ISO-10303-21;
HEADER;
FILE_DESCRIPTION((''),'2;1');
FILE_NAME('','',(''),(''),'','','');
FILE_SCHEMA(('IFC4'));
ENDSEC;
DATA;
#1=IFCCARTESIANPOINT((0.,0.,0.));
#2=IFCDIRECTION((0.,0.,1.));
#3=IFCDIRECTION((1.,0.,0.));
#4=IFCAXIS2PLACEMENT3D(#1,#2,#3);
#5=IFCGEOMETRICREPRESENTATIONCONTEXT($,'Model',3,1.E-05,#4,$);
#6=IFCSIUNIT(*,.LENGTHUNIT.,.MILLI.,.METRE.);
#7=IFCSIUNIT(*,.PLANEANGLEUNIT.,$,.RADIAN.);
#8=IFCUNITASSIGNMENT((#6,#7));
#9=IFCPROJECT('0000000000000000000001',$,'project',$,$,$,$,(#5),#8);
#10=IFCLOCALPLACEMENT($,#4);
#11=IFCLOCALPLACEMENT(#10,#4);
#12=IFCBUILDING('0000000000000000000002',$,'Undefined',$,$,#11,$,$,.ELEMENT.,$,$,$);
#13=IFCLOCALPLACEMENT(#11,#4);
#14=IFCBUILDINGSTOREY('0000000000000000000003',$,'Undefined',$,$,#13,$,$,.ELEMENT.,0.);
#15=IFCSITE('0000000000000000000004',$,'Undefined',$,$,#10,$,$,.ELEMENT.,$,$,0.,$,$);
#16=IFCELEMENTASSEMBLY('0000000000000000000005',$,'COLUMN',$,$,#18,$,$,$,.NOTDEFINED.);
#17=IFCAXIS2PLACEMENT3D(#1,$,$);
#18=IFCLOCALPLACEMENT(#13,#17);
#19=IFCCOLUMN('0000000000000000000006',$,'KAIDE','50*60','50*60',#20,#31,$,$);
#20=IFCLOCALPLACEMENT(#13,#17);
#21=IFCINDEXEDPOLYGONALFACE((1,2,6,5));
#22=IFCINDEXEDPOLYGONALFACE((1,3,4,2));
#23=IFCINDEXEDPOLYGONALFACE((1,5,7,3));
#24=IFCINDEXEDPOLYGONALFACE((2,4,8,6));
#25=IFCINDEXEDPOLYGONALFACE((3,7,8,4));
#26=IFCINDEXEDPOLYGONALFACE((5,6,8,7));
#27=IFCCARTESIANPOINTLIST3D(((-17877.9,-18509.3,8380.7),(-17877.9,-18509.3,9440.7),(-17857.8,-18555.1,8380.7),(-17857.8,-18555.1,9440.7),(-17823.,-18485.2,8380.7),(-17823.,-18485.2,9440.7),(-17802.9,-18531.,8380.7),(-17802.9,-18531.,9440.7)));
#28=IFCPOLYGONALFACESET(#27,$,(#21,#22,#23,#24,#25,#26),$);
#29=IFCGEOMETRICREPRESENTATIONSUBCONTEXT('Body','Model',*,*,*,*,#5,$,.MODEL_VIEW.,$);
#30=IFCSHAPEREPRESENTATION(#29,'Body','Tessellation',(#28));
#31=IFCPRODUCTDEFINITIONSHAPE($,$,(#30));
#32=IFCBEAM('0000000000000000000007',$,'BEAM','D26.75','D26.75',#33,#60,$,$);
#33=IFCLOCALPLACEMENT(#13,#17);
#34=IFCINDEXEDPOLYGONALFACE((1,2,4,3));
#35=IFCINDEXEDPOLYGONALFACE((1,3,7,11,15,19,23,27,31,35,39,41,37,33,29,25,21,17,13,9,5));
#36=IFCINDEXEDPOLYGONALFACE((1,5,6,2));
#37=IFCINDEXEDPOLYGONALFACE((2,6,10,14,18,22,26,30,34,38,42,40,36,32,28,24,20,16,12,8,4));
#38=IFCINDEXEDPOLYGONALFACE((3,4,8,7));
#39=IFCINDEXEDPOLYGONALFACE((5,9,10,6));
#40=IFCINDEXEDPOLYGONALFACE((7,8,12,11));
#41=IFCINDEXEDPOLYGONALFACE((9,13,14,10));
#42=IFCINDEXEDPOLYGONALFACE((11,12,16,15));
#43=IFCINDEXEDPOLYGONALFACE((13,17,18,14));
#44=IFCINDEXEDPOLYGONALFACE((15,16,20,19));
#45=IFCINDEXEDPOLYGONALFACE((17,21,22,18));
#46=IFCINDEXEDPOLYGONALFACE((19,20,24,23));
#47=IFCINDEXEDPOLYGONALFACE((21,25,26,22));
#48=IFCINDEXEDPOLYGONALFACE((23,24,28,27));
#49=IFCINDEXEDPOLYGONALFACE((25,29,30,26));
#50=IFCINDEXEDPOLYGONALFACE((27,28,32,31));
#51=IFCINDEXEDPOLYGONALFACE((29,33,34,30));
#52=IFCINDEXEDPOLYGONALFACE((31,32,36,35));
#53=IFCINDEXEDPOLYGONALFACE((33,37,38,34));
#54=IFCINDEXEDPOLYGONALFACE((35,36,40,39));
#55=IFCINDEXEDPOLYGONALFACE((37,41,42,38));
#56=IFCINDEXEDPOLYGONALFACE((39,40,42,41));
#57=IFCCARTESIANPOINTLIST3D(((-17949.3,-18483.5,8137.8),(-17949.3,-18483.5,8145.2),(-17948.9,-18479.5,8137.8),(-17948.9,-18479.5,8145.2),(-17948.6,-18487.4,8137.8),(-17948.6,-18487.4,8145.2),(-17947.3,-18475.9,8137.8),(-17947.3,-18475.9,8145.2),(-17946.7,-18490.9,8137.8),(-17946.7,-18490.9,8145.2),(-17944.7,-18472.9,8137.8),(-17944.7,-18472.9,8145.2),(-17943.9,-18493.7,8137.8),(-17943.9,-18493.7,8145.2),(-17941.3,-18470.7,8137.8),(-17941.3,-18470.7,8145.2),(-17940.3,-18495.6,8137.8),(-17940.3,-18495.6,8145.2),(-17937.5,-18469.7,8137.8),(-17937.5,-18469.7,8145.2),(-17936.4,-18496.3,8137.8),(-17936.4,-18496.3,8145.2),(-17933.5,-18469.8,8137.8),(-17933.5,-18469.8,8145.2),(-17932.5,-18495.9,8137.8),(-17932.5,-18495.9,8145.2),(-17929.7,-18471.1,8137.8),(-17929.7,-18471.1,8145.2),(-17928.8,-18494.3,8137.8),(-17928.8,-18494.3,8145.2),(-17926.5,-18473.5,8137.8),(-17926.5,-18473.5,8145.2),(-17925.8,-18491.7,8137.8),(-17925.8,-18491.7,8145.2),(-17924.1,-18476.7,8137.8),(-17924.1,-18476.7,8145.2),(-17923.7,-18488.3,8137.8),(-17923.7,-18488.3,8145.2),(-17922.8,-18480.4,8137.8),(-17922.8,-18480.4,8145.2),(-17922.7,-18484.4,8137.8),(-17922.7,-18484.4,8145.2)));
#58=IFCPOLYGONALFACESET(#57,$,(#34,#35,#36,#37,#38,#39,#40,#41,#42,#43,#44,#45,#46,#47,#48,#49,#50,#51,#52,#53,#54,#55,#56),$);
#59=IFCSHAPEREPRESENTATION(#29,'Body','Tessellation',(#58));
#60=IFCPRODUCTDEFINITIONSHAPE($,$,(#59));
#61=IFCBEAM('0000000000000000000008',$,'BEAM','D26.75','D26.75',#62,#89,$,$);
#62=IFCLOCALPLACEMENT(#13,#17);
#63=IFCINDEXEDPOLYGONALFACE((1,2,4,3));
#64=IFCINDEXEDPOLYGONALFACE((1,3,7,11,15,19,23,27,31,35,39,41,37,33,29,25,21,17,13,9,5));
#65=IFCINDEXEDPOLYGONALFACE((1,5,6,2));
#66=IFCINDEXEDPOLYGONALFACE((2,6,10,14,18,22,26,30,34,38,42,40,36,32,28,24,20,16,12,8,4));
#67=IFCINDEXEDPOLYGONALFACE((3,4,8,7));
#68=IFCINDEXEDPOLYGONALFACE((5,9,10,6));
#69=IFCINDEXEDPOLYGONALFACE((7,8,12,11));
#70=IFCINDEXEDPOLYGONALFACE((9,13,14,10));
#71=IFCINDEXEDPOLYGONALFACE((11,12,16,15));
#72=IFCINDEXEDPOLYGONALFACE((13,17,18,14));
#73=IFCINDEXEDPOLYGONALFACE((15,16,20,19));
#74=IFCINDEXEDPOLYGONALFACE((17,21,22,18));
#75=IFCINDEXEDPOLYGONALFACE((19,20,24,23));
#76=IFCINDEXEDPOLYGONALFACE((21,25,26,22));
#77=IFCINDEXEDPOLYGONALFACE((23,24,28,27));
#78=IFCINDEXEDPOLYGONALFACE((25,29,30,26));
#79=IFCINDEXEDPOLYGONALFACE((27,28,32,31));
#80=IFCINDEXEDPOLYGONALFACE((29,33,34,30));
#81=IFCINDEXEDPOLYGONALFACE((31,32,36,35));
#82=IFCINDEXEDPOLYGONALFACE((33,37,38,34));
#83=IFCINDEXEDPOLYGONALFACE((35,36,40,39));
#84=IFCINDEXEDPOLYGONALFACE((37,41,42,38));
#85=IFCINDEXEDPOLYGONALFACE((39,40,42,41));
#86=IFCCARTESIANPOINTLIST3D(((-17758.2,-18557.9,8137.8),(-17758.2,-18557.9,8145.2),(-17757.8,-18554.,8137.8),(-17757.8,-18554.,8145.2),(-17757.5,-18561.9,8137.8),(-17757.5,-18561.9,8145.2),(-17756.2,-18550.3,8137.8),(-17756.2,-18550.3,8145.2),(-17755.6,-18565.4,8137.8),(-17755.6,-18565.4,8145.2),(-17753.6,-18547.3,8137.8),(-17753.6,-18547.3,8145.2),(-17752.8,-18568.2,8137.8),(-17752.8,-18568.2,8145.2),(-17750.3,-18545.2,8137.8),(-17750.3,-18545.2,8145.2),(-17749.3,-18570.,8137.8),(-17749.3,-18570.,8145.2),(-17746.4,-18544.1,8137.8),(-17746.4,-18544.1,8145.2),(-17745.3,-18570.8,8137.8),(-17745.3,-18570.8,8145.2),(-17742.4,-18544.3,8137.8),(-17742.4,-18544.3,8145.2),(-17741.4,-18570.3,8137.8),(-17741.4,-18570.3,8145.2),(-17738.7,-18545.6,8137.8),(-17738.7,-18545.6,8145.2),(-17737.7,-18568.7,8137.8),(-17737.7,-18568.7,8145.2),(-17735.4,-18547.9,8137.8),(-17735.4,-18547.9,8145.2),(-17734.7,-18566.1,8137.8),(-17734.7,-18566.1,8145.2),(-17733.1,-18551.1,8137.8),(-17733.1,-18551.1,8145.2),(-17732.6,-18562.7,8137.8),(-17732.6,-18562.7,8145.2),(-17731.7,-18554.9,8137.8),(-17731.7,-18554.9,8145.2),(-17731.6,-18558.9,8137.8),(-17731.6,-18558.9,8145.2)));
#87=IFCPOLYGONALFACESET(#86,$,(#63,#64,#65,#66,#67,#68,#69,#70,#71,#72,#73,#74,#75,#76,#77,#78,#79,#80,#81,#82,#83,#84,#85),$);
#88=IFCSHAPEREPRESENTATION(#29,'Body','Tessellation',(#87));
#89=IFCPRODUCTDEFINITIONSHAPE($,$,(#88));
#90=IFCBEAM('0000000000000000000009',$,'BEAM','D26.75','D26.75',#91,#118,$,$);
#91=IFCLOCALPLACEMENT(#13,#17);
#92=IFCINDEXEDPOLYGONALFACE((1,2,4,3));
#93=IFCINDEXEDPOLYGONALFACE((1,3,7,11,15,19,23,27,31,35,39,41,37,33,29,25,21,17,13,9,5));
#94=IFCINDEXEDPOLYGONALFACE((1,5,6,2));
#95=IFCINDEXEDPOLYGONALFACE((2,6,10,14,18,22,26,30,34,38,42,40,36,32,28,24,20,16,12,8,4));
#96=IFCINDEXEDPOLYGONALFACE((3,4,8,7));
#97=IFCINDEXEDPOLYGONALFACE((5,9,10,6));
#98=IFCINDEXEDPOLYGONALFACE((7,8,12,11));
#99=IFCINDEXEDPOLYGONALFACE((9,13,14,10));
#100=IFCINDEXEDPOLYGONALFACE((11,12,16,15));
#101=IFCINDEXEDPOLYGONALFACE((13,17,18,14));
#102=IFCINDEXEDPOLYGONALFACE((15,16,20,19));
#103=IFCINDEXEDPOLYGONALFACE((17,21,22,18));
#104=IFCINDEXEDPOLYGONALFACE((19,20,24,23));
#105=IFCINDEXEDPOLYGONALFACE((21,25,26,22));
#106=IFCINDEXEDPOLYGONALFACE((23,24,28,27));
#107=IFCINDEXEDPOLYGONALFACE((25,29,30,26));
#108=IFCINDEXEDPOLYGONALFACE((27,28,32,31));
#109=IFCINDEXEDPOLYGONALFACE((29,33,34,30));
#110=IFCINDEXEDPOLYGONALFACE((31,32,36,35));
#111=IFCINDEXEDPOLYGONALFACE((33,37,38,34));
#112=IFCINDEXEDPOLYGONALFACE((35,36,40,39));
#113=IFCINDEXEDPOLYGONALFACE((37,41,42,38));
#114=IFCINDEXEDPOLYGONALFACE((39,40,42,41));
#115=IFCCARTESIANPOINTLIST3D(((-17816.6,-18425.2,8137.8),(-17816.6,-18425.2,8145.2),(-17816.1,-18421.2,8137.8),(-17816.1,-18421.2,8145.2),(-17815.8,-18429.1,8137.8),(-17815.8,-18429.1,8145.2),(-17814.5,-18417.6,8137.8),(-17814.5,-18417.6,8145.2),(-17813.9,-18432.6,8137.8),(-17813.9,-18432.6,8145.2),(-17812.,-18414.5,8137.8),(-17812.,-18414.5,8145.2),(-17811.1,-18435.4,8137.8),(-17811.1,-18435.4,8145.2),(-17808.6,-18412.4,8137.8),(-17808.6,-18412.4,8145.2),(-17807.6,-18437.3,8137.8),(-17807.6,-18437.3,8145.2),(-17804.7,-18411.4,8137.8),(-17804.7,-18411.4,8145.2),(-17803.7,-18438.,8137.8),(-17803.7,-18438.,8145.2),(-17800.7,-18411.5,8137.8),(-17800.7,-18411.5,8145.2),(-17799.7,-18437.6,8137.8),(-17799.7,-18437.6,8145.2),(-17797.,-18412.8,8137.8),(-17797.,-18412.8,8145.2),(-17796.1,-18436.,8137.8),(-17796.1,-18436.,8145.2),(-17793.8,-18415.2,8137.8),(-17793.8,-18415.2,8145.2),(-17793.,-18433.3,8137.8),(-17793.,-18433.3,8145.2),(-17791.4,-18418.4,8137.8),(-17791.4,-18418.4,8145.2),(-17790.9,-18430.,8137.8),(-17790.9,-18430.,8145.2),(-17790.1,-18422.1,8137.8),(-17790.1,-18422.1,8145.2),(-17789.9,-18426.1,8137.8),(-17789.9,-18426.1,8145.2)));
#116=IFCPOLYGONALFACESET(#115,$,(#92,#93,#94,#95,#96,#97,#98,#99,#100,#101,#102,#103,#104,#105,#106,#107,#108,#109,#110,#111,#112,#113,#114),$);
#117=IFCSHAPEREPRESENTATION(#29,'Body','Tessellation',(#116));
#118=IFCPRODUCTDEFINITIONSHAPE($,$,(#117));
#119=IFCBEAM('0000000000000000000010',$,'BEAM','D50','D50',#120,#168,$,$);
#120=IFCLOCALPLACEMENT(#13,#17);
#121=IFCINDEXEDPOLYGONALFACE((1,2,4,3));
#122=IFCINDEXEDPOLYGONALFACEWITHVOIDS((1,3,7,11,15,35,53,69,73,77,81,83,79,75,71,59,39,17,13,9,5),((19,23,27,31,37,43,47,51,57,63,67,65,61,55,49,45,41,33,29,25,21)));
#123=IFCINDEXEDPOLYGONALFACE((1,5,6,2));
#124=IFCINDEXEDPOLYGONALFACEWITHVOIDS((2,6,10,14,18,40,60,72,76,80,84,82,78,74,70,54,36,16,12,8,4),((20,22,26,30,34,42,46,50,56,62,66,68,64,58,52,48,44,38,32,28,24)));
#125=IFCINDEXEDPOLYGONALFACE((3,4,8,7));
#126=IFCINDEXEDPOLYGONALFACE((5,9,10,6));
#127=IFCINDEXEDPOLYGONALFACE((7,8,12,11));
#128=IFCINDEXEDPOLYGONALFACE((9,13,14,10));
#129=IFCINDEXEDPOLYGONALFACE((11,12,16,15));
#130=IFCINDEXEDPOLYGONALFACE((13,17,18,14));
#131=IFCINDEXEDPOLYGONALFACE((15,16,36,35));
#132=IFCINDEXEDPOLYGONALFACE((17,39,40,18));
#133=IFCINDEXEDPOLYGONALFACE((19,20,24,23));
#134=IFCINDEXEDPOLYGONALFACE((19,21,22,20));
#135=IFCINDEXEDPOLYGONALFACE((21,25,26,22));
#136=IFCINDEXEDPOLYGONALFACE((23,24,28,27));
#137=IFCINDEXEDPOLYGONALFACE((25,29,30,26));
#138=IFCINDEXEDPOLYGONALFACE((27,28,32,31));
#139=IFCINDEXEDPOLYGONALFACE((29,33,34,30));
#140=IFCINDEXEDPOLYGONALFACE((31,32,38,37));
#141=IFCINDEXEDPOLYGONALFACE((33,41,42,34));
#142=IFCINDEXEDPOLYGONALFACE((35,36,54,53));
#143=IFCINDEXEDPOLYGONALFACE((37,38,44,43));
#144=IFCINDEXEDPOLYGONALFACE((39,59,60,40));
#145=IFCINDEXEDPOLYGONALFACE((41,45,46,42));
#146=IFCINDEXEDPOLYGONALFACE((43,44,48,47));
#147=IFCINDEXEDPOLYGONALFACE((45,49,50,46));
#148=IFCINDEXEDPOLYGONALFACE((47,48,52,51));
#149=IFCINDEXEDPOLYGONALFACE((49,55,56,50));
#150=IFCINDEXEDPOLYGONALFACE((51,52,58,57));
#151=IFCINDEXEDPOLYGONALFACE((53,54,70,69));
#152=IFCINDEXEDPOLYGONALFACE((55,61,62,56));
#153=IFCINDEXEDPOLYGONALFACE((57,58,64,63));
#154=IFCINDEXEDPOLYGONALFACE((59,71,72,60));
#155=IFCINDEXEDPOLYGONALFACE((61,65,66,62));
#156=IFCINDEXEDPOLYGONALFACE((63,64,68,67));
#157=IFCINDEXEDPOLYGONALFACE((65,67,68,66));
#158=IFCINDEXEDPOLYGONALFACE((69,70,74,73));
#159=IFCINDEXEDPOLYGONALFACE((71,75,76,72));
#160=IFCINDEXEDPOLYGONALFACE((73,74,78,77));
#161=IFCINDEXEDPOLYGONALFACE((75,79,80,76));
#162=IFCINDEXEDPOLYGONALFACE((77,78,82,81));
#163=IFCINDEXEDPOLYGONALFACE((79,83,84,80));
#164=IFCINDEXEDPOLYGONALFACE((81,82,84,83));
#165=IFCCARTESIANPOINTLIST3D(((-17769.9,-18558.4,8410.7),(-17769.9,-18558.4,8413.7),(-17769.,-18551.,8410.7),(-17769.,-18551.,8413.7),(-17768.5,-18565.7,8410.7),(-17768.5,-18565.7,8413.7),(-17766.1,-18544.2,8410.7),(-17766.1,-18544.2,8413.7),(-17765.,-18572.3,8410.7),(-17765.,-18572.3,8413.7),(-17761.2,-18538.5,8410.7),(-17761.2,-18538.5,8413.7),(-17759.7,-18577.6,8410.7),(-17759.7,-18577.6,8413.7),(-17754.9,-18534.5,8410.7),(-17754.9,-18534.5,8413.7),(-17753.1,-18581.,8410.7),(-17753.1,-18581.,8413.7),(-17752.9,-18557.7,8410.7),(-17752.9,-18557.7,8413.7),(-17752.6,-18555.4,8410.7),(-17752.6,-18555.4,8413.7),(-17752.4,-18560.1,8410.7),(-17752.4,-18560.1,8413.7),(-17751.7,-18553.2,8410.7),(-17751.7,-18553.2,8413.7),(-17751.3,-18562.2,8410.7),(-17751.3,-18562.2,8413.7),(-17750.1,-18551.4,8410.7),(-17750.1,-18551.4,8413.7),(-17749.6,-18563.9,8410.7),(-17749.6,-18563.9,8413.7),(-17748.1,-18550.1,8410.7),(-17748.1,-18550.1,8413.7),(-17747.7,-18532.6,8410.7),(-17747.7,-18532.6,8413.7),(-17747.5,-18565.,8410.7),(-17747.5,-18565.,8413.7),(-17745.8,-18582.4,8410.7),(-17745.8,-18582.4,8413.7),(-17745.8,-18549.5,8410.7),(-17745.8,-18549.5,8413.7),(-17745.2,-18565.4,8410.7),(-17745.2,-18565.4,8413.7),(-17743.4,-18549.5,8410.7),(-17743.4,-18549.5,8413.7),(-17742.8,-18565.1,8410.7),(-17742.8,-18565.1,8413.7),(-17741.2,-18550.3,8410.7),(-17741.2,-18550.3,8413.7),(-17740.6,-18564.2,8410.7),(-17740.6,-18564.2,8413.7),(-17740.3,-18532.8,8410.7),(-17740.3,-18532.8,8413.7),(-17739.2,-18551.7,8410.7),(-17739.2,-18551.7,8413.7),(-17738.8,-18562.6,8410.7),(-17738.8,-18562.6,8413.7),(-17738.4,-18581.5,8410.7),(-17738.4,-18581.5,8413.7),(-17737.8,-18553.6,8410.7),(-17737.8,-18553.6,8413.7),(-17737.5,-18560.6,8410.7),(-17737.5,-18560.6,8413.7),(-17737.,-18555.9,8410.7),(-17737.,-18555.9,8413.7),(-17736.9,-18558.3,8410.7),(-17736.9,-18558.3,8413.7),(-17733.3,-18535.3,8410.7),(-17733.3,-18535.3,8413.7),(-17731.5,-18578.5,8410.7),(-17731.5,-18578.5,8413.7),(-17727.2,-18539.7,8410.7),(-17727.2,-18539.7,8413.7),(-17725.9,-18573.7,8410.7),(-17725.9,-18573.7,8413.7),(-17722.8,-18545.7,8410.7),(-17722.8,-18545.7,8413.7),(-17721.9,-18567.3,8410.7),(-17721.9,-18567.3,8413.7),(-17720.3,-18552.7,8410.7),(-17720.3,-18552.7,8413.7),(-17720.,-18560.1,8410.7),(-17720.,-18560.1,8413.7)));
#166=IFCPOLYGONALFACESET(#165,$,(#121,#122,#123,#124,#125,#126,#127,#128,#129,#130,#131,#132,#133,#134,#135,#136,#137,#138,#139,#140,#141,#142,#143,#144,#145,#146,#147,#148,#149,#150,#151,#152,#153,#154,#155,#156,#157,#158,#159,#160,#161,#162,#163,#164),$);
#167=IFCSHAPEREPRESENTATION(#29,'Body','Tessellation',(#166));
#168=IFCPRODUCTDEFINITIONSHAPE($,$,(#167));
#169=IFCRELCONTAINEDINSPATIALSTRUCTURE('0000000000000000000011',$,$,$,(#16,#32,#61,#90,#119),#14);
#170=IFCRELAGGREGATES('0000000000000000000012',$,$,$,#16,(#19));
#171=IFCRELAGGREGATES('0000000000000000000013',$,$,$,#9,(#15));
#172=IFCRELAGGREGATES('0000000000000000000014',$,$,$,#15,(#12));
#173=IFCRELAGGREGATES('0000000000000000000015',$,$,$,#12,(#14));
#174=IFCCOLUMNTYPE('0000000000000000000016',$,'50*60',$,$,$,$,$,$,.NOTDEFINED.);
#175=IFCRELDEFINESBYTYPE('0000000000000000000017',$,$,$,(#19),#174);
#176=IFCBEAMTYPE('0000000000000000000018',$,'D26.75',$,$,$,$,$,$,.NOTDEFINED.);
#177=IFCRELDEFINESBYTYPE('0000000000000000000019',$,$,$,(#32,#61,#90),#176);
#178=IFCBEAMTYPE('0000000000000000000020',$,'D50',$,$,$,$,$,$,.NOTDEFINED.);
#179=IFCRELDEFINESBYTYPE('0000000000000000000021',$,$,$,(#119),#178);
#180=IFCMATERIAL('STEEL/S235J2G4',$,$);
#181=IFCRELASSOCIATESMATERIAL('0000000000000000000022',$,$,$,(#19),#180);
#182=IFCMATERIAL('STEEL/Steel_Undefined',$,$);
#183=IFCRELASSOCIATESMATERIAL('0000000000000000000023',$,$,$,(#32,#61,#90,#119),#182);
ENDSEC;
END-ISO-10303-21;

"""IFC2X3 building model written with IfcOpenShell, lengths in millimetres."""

from ifc_helpers import new_model, si_unit, frame, origin_with_axes, origin_2d_with_axis, place, context, subcontext, project, spatial, rectangle, circle, extrude, material, type_object, element, aggregate, save


model = new_model("IFC2X3")

# Units and contexts
model_context = context("Model", 3, precision=1e-05, world=origin_with_axes())
body_context = subcontext(model_context, "Body", "Model", "MODEL_VIEW")
ifc_project = project(units=[si_unit("LENGTHUNIT", "METRE", prefix="MILLI"), si_unit("PLANEANGLEUNIT", "RADIAN")], contexts=[model_context])

# Site, building, storey
site_placement = place(None, origin_with_axes())
site = spatial("IfcSite", under=ifc_project, at=site_placement, Name="Undefined", CompositionType="ELEMENT", RefElevation=0.0)
building_placement = place(site_placement, origin_with_axes())
building = spatial("IfcBuilding", under=site, at=building_placement, Name="Undefined", CompositionType="ELEMENT")
storey_placement = place(building_placement, origin_with_axes())
storey = spatial("IfcBuildingStorey", under=building, at=storey_placement, Name="Undefined", CompositionType="ELEMENT", Elevation=0.0)

# Element assembly, column
assembly_placement = place(storey_placement, frame((-17840.4, -18520.2, 8380.7), z_axis=(-0.402198, 0.915553, 0.0), x_axis=(0.0, 0.0, 1.0)))
assembly = element("IfcElementAssembly", 1, at=assembly_placement, inside=storey, Name="COLUMN", PredefinedType="NOTDEFINED")
ifc_material_1 = material(Name="STEEL/S235J2G4")
column_type = type_object("IfcColumnType", Name="50*60", PredefinedType="NOTDEFINED")
column_placement = place(storey_placement, frame((-17840.4, -18520.2, 8380.7), z_axis=(0.0, 0.0, 1.0), x_axis=(1.0, 0.0, 0.0)))
column = element("IfcColumn", 2, at=column_placement, type_object=column_type, material=ifc_material_1, Name="KAIDE", Description="50*60", ObjectType="50*60", context=body_context, shape_type="SweptSolid", body=[
    extrude(rectangle(XDim=60.0, YDim=50.0, at=origin_2d_with_axis()), frame((0.0, 0.0, 1060.0), z_axis=(0.0, 0.0, -1.0), x_axis=(-0.915553, -0.402198, 0.0)), (0.0, 0.0, 1.0), 1060.0),
])
aggregate(assembly, [column])

# Shared definitions
ifc_material_2 = material(Name="STEEL/Steel_Undefined")
beam_type_1 = type_object("IfcBeamType", Name="D26.75", PredefinedType="NOTDEFINED")

# Beams
for number, where, z_axis, x_axis, name in (
    (3, (-17936.0, -18483.0, 8145.2), (-0.915553, -0.402198, 0.0), (0.0, 0.0, -1.0), "BEAM"),
    (4, (-17744.9, -18557.4, 8145.2), (-0.915553, -0.402198, 0.0), (0.0, 0.0, -1.0), "BEAM"),
):
    element("IfcBeam", number, at=place(storey_placement, frame(where, z_axis=z_axis, x_axis=x_axis)), inside=storey, type_object=beam_type_1, material=ifc_material_2, Name=name, Description="D26.75", ObjectType="D26.75", context=body_context, shape_type="SweptSolid", body=[
        extrude(circle(Radius=13.4, at=origin_2d_with_axis()), frame((7.4, 0.0, 0.0), z_axis=(-1.0, 0.0, 0.0), x_axis=(0.0, -1.0, 0.0)), (0.0, 0.0, 1.0), 7.4),
    ])

# Beam
beam_1_placement = place(storey_placement, frame((-17803.2, -18424.6, 8145.2), z_axis=(-0.915553, -0.402198, 0.0), x_axis=(0.0, 0.0, -1.0)))
element("IfcBeam", 5, at=beam_1_placement, inside=storey, type_object=beam_type_1, material=ifc_material_2, Name="BEAM", Description="D26.75", ObjectType="D26.75", context=body_context, shape_type="SweptSolid", body=[
    extrude(circle(Radius=13.4, at=origin_2d_with_axis()), frame((7.4, 0.0, 0.0), z_axis=(-1.0, 0.0, 0.0), x_axis=(0.0, -1.0, 0.0)), (0.0, 0.0, 1.0), 7.4),
])

# Beam, opening
beam_type_2 = type_object("IfcBeamType", Name="D50", PredefinedType="NOTDEFINED")
beam_2_placement = place(storey_placement, frame((-17744.9, -18557.4, 8413.7), z_axis=(-0.915553, -0.402198, 0.0), x_axis=(0.0, 0.0, -1.0)))
beam_2 = element("IfcBeam", 6, at=beam_2_placement, inside=storey, type_object=beam_type_2, material=ifc_material_2, Name="BEAM", Description="D50", ObjectType="D50", context=body_context, shape_type="SweptSolid", body=[
    extrude(circle(Radius=25.0, at=origin_2d_with_axis()), frame((3.0, 0.0, 0.0), z_axis=(-1.0, 0.0, 0.0), x_axis=(0.0, -1.0, 0.0)), (0.0, 0.0, 1.0), 3.0),
])
opening_1_placement = place(storey_placement, frame((-17744.9, -18557.4, 8413.7), z_axis=(-0.915553, -0.402198, 0.0), x_axis=(0.0, 0.0, -1.0)))
element("IfcOpeningElement", 7, at=opening_1_placement, cuts=beam_2, ObjectType="Recess", context=body_context, shape_type="SweptSolid", body=[
    extrude(circle(Radius=8.0, at=origin_2d_with_axis()), frame((268.5, 0.0, 0.0), z_axis=(-1.0, 0.0, 0.0), x_axis=(0.0, -1.0, 0.0)), (0.0, 0.0, 1.0), 292.6),
])

save(model, "model.ifc")
